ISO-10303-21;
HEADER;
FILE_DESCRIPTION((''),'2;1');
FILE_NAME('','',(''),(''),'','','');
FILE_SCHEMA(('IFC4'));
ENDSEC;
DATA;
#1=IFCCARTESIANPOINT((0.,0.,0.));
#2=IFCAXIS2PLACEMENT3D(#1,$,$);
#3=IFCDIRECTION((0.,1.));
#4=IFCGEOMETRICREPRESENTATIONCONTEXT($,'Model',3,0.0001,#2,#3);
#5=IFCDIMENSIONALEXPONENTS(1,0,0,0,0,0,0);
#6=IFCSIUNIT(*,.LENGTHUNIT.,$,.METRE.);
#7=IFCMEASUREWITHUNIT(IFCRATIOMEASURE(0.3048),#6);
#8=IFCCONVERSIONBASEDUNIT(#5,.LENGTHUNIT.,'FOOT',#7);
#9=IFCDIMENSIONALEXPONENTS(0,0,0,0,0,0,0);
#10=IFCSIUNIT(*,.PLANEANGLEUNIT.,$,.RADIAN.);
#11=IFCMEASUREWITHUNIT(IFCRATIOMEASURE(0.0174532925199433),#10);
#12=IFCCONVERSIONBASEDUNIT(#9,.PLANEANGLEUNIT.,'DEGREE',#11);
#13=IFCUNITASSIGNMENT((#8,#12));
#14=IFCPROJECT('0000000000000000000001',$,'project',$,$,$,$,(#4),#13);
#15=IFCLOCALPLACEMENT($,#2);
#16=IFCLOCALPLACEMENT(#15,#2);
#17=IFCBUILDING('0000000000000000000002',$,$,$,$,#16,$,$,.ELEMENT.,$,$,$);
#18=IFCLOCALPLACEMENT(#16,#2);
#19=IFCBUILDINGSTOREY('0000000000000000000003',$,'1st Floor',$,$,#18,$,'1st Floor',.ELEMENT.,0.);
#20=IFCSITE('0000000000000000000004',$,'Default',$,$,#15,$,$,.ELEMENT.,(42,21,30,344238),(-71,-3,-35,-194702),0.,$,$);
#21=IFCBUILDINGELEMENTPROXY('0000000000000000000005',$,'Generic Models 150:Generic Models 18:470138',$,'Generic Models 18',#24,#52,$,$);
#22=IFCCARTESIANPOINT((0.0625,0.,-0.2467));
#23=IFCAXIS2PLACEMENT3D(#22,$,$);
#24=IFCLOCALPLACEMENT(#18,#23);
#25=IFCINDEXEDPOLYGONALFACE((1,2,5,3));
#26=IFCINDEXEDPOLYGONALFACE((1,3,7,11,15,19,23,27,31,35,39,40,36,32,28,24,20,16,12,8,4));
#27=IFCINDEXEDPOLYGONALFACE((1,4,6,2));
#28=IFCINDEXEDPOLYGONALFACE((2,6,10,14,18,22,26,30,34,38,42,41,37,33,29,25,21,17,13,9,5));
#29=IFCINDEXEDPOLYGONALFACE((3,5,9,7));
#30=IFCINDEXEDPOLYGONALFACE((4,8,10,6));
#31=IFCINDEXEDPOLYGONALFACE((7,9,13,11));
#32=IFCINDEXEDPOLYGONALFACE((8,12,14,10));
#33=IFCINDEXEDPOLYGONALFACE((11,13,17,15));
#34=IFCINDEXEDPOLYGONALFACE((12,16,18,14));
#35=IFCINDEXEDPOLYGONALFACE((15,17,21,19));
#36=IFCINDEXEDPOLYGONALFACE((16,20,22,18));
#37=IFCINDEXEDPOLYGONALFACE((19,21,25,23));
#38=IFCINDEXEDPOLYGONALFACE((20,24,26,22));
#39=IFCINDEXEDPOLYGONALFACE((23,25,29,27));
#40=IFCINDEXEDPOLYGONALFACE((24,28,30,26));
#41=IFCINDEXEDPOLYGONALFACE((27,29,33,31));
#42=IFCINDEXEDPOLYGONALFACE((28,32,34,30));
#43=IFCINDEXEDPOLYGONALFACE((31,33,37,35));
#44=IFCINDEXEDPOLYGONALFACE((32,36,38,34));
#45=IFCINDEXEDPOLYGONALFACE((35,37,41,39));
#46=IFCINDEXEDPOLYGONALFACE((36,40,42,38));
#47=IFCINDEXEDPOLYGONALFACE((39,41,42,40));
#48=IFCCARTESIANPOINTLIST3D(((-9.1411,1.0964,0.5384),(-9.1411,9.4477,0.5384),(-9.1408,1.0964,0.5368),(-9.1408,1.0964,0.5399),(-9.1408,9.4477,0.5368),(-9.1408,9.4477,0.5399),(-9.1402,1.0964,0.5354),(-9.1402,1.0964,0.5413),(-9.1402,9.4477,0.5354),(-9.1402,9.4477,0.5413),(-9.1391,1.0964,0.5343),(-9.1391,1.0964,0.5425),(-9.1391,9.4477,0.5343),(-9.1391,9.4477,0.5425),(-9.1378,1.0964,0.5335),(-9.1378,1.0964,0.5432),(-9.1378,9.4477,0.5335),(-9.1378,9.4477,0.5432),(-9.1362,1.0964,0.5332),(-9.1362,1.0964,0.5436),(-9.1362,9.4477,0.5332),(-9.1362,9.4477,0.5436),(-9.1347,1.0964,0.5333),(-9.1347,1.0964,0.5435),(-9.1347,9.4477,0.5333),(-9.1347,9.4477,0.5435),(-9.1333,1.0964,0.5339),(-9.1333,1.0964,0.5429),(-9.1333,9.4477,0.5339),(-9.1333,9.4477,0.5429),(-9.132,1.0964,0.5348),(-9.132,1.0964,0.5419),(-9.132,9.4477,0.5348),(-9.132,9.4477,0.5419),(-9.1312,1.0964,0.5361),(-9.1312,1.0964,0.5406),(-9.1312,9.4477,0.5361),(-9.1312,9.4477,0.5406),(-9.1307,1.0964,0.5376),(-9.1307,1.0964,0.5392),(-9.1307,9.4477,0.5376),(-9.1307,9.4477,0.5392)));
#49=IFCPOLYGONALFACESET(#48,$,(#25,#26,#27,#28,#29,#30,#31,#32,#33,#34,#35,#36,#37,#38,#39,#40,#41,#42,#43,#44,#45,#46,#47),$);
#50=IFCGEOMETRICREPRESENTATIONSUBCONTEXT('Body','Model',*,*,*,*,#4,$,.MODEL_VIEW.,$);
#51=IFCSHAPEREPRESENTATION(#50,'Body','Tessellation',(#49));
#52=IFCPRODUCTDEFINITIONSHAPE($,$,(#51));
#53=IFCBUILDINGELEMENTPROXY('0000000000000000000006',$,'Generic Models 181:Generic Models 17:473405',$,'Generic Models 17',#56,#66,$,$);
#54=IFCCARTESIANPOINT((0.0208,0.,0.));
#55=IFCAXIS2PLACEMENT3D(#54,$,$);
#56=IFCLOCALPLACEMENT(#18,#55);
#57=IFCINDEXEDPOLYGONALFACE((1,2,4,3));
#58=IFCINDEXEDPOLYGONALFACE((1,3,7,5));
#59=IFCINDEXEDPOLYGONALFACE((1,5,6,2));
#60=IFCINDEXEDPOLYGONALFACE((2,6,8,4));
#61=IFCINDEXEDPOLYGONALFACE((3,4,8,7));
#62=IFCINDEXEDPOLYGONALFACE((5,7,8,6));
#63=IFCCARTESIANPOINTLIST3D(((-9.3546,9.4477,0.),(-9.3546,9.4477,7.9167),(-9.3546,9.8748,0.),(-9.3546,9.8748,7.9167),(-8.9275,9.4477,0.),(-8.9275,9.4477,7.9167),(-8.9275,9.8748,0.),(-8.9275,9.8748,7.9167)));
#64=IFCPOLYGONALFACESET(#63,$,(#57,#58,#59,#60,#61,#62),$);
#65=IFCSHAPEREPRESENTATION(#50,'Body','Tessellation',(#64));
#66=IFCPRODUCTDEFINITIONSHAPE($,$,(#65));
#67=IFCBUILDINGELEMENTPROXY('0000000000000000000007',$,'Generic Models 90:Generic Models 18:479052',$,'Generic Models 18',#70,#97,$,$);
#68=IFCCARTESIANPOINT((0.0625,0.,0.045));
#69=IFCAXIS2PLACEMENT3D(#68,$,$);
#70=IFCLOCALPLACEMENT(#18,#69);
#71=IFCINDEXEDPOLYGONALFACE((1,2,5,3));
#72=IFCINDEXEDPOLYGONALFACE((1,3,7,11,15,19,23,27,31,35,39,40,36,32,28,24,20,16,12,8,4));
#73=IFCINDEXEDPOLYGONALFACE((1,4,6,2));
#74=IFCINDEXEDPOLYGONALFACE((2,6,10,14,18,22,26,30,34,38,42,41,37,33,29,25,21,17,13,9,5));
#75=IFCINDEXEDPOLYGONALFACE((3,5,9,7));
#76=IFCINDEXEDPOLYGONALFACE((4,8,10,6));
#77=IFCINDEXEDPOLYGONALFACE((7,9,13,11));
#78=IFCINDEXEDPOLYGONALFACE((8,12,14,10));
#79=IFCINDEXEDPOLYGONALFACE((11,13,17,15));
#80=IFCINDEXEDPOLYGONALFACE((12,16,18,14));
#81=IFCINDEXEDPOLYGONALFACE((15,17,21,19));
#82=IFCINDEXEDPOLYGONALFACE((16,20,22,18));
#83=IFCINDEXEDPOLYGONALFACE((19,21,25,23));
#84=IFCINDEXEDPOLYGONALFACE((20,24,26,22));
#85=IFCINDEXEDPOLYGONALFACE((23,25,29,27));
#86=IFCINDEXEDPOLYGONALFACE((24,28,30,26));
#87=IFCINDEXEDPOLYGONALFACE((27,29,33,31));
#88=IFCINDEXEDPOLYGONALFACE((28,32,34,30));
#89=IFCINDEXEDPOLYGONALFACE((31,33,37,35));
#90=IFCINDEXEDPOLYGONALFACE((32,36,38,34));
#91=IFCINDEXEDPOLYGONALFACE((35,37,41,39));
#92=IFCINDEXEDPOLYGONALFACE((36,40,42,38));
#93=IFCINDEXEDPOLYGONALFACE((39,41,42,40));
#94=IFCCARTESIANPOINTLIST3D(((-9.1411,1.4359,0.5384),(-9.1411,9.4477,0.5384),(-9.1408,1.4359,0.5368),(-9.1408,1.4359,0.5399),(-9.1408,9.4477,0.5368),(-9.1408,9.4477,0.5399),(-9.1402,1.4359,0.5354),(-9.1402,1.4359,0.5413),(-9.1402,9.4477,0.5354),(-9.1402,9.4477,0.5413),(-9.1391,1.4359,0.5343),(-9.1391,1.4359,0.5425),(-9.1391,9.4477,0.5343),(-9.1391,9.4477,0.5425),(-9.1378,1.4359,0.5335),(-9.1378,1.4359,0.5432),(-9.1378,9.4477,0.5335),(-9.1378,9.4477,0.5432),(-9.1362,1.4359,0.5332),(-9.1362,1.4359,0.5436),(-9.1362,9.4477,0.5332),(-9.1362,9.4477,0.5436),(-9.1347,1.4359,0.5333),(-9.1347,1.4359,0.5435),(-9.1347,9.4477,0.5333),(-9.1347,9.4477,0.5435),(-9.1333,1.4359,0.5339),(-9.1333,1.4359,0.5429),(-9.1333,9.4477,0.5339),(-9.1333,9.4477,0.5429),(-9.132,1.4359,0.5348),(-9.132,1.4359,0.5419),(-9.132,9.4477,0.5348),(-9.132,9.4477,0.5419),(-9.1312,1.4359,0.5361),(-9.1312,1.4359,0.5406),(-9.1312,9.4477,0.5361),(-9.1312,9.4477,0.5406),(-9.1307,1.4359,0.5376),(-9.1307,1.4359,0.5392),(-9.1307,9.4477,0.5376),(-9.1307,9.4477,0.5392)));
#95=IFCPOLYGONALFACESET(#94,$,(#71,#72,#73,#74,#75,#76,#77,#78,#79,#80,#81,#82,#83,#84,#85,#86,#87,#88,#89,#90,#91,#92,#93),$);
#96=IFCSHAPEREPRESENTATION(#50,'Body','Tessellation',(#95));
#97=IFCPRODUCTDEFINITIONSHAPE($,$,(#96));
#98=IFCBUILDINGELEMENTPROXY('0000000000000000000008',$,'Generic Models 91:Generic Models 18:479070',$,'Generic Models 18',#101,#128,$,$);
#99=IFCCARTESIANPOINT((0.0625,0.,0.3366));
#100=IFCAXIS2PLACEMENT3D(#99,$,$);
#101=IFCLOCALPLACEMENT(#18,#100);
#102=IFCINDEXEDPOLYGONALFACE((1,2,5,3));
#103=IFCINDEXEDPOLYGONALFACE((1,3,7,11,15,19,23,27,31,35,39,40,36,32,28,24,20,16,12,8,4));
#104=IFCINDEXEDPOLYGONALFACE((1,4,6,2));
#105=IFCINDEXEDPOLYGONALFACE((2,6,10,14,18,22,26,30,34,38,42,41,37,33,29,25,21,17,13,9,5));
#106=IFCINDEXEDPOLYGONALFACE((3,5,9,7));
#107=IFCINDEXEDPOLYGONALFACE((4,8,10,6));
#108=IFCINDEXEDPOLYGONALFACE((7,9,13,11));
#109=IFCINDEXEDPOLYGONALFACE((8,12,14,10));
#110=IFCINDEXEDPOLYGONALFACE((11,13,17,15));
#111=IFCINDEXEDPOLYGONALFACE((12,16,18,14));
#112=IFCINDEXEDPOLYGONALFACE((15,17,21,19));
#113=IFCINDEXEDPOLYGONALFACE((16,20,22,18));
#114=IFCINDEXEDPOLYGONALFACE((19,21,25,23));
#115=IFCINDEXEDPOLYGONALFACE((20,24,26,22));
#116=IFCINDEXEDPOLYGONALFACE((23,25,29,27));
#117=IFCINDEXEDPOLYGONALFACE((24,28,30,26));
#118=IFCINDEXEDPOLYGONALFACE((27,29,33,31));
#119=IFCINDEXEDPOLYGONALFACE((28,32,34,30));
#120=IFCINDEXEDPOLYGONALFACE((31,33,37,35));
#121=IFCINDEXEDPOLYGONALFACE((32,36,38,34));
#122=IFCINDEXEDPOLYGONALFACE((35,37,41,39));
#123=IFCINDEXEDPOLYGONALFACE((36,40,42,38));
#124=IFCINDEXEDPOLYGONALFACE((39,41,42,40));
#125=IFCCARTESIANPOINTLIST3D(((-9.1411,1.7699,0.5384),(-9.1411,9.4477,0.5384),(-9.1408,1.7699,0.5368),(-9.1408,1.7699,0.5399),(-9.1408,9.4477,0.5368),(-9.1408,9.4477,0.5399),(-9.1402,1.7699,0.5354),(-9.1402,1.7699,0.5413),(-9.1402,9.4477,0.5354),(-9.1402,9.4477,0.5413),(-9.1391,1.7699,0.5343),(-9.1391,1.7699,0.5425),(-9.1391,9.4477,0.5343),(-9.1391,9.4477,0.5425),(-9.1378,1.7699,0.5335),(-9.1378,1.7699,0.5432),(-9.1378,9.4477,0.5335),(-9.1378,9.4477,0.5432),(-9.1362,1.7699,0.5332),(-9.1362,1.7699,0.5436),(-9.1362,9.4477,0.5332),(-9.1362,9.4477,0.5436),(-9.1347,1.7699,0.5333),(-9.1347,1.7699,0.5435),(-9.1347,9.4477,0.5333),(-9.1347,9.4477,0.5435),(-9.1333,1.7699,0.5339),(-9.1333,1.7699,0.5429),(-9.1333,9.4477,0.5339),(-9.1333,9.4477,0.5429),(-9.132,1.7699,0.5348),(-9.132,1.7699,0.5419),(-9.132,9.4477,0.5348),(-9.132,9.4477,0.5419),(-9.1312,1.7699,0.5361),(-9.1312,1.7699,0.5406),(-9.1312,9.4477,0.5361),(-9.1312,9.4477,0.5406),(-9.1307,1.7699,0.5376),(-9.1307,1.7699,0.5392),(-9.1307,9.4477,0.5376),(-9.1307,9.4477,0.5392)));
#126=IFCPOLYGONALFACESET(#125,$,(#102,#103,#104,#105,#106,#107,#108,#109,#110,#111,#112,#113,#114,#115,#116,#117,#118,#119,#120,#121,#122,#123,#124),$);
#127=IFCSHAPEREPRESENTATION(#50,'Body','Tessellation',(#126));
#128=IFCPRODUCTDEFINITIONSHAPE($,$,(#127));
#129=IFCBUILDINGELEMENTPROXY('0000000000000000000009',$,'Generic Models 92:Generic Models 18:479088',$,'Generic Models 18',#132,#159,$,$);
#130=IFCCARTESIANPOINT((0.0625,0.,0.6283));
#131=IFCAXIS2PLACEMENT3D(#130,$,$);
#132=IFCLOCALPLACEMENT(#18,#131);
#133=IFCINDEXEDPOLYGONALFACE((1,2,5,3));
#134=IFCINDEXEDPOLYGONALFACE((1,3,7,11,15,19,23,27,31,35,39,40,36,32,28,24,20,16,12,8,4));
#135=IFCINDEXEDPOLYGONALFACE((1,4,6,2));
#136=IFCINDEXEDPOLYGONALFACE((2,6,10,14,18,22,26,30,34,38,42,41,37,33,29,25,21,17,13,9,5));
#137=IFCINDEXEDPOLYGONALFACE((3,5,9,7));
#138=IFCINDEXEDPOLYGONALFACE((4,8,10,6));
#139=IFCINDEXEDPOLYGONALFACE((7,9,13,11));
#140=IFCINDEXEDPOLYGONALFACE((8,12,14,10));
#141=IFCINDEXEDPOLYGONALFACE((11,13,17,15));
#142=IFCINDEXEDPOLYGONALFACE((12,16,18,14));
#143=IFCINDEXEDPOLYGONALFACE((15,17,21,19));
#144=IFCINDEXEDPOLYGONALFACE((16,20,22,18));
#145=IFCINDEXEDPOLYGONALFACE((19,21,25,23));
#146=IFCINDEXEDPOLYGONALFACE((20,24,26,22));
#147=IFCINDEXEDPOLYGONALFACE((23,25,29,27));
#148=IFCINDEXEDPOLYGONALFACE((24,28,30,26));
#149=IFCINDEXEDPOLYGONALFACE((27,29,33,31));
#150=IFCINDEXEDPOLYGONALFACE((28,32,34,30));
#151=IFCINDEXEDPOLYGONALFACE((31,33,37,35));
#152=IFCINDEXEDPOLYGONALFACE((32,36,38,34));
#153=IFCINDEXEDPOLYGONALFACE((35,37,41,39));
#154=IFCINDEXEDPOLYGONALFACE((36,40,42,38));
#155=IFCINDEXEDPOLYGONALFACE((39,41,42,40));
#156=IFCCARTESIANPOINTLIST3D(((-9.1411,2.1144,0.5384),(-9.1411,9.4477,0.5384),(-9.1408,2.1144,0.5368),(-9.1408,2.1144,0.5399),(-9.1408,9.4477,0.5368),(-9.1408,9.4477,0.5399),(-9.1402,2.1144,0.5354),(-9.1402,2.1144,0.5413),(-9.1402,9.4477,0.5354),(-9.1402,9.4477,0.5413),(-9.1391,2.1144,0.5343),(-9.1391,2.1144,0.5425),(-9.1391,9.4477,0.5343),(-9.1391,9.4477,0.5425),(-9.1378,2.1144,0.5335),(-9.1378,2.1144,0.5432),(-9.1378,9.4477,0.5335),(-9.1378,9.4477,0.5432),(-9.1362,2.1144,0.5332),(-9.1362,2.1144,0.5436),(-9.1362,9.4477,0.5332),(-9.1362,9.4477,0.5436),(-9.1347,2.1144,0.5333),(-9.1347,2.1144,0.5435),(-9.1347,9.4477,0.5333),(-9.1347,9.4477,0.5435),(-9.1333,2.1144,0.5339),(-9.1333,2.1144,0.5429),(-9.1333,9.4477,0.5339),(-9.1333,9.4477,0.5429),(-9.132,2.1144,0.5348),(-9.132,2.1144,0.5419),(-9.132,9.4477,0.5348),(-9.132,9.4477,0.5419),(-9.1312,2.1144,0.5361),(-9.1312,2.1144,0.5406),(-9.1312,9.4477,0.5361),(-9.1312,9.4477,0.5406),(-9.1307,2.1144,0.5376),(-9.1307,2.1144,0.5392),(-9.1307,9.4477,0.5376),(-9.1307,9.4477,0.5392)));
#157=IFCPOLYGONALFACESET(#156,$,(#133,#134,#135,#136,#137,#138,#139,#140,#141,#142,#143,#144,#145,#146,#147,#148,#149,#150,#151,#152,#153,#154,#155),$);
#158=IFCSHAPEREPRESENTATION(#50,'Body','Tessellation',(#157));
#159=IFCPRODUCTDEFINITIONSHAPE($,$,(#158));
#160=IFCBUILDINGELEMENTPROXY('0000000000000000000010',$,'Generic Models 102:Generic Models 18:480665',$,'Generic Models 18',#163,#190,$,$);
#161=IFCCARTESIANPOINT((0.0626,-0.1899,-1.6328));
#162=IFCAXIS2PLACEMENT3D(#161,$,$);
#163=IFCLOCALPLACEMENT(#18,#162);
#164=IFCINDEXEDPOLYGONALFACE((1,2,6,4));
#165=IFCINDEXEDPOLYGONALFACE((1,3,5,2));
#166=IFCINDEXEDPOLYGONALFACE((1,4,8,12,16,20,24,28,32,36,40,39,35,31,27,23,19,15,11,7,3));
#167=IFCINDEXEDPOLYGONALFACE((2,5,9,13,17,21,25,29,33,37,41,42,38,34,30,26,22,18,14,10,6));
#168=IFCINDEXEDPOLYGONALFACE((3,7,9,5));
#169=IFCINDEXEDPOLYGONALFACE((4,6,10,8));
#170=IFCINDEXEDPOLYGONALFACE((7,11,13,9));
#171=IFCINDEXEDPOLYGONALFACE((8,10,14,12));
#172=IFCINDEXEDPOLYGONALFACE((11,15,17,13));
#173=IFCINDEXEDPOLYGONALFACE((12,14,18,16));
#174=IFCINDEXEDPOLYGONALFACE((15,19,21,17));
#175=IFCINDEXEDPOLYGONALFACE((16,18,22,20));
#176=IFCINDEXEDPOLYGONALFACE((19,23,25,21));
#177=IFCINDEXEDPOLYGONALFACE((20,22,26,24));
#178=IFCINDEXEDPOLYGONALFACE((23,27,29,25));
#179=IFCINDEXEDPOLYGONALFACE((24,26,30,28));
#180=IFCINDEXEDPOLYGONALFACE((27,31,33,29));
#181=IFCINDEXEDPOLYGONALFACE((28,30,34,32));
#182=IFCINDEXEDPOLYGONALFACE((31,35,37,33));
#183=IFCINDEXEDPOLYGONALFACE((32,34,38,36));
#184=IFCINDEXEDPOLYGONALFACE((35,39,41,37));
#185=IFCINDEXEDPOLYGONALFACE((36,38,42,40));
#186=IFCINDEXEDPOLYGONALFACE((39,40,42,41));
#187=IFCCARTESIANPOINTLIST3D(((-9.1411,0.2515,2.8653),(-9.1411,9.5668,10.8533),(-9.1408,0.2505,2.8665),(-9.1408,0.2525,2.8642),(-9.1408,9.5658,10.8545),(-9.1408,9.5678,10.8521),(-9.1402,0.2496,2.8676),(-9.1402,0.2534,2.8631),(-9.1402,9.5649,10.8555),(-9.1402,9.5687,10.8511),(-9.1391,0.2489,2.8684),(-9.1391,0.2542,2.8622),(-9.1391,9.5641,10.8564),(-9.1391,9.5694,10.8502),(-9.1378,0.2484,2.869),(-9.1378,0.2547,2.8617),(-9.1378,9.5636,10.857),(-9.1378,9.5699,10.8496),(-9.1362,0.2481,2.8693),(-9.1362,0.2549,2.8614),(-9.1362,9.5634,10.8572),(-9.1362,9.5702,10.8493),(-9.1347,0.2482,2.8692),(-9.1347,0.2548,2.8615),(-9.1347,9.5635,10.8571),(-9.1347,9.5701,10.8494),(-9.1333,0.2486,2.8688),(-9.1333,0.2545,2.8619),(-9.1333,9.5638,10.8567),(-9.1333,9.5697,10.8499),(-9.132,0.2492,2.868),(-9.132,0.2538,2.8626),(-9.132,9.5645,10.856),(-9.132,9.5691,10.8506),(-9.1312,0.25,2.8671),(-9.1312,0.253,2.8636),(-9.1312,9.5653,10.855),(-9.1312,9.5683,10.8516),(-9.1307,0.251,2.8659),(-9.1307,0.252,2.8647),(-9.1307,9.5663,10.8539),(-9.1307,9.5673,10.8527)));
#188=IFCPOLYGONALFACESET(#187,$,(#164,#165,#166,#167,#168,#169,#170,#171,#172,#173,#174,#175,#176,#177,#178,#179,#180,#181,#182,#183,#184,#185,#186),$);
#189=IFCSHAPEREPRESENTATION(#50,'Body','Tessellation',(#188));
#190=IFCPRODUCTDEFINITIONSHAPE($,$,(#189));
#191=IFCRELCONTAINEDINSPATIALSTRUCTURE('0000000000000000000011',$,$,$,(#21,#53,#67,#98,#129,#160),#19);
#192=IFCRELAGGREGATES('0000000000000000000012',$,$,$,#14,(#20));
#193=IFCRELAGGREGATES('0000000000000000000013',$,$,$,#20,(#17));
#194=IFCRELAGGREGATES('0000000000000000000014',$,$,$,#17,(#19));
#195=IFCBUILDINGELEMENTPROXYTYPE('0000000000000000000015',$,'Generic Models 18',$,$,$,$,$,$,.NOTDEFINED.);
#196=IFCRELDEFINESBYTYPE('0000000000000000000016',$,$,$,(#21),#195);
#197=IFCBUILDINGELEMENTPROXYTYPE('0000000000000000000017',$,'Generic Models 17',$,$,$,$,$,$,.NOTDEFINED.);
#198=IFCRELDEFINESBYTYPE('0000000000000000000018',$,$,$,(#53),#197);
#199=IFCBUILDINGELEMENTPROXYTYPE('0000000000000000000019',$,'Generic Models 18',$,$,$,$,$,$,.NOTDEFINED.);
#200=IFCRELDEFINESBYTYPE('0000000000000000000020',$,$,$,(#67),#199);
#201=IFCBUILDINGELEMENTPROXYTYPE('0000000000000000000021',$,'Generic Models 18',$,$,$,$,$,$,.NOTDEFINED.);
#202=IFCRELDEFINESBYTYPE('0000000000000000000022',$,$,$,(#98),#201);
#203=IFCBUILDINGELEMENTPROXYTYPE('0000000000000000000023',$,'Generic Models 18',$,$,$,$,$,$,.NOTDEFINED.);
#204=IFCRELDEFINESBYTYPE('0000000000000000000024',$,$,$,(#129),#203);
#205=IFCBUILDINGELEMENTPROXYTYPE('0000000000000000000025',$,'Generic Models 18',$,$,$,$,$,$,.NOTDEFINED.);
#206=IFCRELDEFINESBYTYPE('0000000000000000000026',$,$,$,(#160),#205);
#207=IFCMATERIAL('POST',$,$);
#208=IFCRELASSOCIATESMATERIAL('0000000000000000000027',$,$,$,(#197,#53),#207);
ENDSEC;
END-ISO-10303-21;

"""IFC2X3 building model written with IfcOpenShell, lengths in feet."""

from ifc_helpers import new_model, entity, si_unit, converted_unit, direction, frame, origin, origin_2d_with_axis, place, context, subcontext, project, spatial, rectangle, circle, extrude, source, transform, mapped, material, type_object, type_shapes, element, save


model = new_model("IFC2X3")

# Units and contexts
model_context = context("Model", 3, precision=0.0001, world=origin(), true_north=direction((0.0, 1.0)))
body_context = subcontext(model_context, "Body", "Model", "MODEL_VIEW")
ifc_project = project(units=[converted_unit("LENGTHUNIT", "FOOT", entity("IfcRatioMeasure", 0.3048), si_unit("LENGTHUNIT", "METRE"), dimensions=[1, 0, 0, 0, 0, 0, 0]), converted_unit("PLANEANGLEUNIT", "DEGREE", entity("IfcRatioMeasure", 0.0174532925199433), si_unit("PLANEANGLEUNIT", "RADIAN"), dimensions=[0, 0, 0, 0, 0, 0, 0])], contexts=[model_context])

# Site, building, storey
site_placement = place(None, origin())
site = spatial("IfcSite", under=ifc_project, at=site_placement, Name="Default", CompositionType="ELEMENT", RefLatitude=(42, 21, 30, 344238), RefLongitude=(-71, -3, -35, -194702), RefElevation=0.0)
building_placement = place(site_placement, origin())
building = spatial("IfcBuilding", under=site, at=building_placement, CompositionType="ELEMENT")
storey_placement = place(building_placement, origin())
storey = spatial("IfcBuildingStorey", under=building, at=storey_placement, Name="1st Floor", LongName="1st Floor", CompositionType="ELEMENT", Elevation=0.0)

# Building element proxies
ifc_material_1 = material(Name="POST")
building_element_proxy_type_1 = type_object("IfcBuildingElementProxyType", Name="Generic Models 18", PredefinedType="NOTDEFINED")
shared_shape_1 = source(origin(), body_context, "Body", "SweptSolid", [
    extrude(circle(Radius=0.0052, at=origin_2d_with_axis()), frame((-9.1359, 1.0964, 0.5384), z_axis=(0.0, 1.0, 0.0), x_axis=(-1.0, 0.0, 0.0)), (0.0, 0.0, 1.0), 8.3512),
])
type_shapes(building_element_proxy_type_1, [shared_shape_1])
proxy_1_placement = place(storey_placement, frame((0.0625, 0.0, -0.2467)))
element("IfcBuildingElementProxy", 1, at=proxy_1_placement, inside=storey, type_object=building_element_proxy_type_1, Name="Generic Models 150:Generic Models 18:470138", ObjectType="Generic Models 18", context=body_context, shape_type="MappedRepresentation", body=[
    mapped(shared_shape_1, transform((0.0, 0.0, 0.0), scale=1.0)),
])
building_element_proxy_type_2 = type_object("IfcBuildingElementProxyType", Name="Generic Models 17", PredefinedType="NOTDEFINED", material=ifc_material_1)
shared_shape_2 = source(origin(), body_context, "Body", "SweptSolid", [
    extrude(rectangle(XDim=0.4271, YDim=0.4271, at=origin_2d_with_axis()), frame((-9.141, 9.6612, 0.0), z_axis=(0.0, 0.0, 1.0), x_axis=(0.0, 1.0, 0.0)), (0.0, 0.0, 1.0), 7.9167),
])
type_shapes(building_element_proxy_type_2, [shared_shape_2])
proxy_2_placement = place(storey_placement, frame((0.0208, 0.0, 0.0)))
element("IfcBuildingElementProxy", 2, at=proxy_2_placement, inside=storey, type_object=building_element_proxy_type_2, material=ifc_material_1, Name="Generic Models 181:Generic Models 17:473405", ObjectType="Generic Models 17", context=body_context, shape_type="MappedRepresentation", body=[
    mapped(shared_shape_2, transform((0.0, 0.0, 0.0), scale=1.0)),
])
building_element_proxy_type_3 = type_object("IfcBuildingElementProxyType", Name="Generic Models 18", PredefinedType="NOTDEFINED")
shared_shape_3 = source(origin(), body_context, "Body", "SweptSolid", [
    extrude(circle(Radius=0.0052, at=origin_2d_with_axis()), frame((-9.1359, 1.4359, 0.5384), z_axis=(0.0, 1.0, 0.0), x_axis=(-1.0, 0.0, 0.0)), (0.0, 0.0, 1.0), 8.0118),
])
type_shapes(building_element_proxy_type_3, [shared_shape_3])
proxy_3_placement = place(storey_placement, frame((0.0625, 0.0, 0.045)))
element("IfcBuildingElementProxy", 3, at=proxy_3_placement, inside=storey, type_object=building_element_proxy_type_3, Name="Generic Models 90:Generic Models 18:479052", ObjectType="Generic Models 18", context=body_context, shape_type="MappedRepresentation", body=[
    mapped(shared_shape_3, transform((0.0, 0.0, 0.0), scale=1.0)),
])
building_element_proxy_type_4 = type_object("IfcBuildingElementProxyType", Name="Generic Models 18", PredefinedType="NOTDEFINED")
shared_shape_4 = source(origin(), body_context, "Body", "SweptSolid", [
    extrude(circle(Radius=0.0052, at=origin_2d_with_axis()), frame((-9.1359, 1.7699, 0.5384), z_axis=(0.0, 1.0, 0.0), x_axis=(-1.0, 0.0, 0.0)), (0.0, 0.0, 1.0), 7.6778),
])
type_shapes(building_element_proxy_type_4, [shared_shape_4])
proxy_4_placement = place(storey_placement, frame((0.0625, 0.0, 0.3366)))
element("IfcBuildingElementProxy", 4, at=proxy_4_placement, inside=storey, type_object=building_element_proxy_type_4, Name="Generic Models 91:Generic Models 18:479070", ObjectType="Generic Models 18", context=body_context, shape_type="MappedRepresentation", body=[
    mapped(shared_shape_4, transform((0.0, 0.0, 0.0), scale=1.0)),
])
building_element_proxy_type_5 = type_object("IfcBuildingElementProxyType", Name="Generic Models 18", PredefinedType="NOTDEFINED")
shared_shape_5 = source(origin(), body_context, "Body", "SweptSolid", [
    extrude(circle(Radius=0.0052, at=origin_2d_with_axis()), frame((-9.1359, 2.1144, 0.5384), z_axis=(0.0, 1.0, 0.0), x_axis=(-1.0, 0.0, 0.0)), (0.0, 0.0, 1.0), 7.3333),
])
type_shapes(building_element_proxy_type_5, [shared_shape_5])
proxy_5_placement = place(storey_placement, frame((0.0625, 0.0, 0.6283)))
element("IfcBuildingElementProxy", 5, at=proxy_5_placement, inside=storey, type_object=building_element_proxy_type_5, Name="Generic Models 92:Generic Models 18:479088", ObjectType="Generic Models 18", context=body_context, shape_type="MappedRepresentation", body=[
    mapped(shared_shape_5, transform((0.0, 0.0, 0.0), scale=1.0)),
])
building_element_proxy_type_6 = type_object("IfcBuildingElementProxyType", Name="Generic Models 18", PredefinedType="NOTDEFINED")
shared_shape_6 = source(origin(), body_context, "Body", "SweptSolid", [
    extrude(circle(Radius=0.0052, at=origin_2d_with_axis()), frame((-9.1359, 0.2515, 2.8653), z_axis=(0.0, 0.759118, 0.650953), x_axis=(-1.0, 0.0, 0.0)), (0.0, 0.0, 1.0), 12.2712),
])
type_shapes(building_element_proxy_type_6, [shared_shape_6])
proxy_6_placement = place(storey_placement, frame((0.0626, -0.1899, -1.6328)))
element("IfcBuildingElementProxy", 6, at=proxy_6_placement, inside=storey, type_object=building_element_proxy_type_6, Name="Generic Models 102:Generic Models 18:480665", ObjectType="Generic Models 18", context=body_context, shape_type="MappedRepresentation", body=[
    mapped(shared_shape_6, transform((0.0, 0.0, 0.0), scale=1.0)),
])

save(model, "model.ifc")
